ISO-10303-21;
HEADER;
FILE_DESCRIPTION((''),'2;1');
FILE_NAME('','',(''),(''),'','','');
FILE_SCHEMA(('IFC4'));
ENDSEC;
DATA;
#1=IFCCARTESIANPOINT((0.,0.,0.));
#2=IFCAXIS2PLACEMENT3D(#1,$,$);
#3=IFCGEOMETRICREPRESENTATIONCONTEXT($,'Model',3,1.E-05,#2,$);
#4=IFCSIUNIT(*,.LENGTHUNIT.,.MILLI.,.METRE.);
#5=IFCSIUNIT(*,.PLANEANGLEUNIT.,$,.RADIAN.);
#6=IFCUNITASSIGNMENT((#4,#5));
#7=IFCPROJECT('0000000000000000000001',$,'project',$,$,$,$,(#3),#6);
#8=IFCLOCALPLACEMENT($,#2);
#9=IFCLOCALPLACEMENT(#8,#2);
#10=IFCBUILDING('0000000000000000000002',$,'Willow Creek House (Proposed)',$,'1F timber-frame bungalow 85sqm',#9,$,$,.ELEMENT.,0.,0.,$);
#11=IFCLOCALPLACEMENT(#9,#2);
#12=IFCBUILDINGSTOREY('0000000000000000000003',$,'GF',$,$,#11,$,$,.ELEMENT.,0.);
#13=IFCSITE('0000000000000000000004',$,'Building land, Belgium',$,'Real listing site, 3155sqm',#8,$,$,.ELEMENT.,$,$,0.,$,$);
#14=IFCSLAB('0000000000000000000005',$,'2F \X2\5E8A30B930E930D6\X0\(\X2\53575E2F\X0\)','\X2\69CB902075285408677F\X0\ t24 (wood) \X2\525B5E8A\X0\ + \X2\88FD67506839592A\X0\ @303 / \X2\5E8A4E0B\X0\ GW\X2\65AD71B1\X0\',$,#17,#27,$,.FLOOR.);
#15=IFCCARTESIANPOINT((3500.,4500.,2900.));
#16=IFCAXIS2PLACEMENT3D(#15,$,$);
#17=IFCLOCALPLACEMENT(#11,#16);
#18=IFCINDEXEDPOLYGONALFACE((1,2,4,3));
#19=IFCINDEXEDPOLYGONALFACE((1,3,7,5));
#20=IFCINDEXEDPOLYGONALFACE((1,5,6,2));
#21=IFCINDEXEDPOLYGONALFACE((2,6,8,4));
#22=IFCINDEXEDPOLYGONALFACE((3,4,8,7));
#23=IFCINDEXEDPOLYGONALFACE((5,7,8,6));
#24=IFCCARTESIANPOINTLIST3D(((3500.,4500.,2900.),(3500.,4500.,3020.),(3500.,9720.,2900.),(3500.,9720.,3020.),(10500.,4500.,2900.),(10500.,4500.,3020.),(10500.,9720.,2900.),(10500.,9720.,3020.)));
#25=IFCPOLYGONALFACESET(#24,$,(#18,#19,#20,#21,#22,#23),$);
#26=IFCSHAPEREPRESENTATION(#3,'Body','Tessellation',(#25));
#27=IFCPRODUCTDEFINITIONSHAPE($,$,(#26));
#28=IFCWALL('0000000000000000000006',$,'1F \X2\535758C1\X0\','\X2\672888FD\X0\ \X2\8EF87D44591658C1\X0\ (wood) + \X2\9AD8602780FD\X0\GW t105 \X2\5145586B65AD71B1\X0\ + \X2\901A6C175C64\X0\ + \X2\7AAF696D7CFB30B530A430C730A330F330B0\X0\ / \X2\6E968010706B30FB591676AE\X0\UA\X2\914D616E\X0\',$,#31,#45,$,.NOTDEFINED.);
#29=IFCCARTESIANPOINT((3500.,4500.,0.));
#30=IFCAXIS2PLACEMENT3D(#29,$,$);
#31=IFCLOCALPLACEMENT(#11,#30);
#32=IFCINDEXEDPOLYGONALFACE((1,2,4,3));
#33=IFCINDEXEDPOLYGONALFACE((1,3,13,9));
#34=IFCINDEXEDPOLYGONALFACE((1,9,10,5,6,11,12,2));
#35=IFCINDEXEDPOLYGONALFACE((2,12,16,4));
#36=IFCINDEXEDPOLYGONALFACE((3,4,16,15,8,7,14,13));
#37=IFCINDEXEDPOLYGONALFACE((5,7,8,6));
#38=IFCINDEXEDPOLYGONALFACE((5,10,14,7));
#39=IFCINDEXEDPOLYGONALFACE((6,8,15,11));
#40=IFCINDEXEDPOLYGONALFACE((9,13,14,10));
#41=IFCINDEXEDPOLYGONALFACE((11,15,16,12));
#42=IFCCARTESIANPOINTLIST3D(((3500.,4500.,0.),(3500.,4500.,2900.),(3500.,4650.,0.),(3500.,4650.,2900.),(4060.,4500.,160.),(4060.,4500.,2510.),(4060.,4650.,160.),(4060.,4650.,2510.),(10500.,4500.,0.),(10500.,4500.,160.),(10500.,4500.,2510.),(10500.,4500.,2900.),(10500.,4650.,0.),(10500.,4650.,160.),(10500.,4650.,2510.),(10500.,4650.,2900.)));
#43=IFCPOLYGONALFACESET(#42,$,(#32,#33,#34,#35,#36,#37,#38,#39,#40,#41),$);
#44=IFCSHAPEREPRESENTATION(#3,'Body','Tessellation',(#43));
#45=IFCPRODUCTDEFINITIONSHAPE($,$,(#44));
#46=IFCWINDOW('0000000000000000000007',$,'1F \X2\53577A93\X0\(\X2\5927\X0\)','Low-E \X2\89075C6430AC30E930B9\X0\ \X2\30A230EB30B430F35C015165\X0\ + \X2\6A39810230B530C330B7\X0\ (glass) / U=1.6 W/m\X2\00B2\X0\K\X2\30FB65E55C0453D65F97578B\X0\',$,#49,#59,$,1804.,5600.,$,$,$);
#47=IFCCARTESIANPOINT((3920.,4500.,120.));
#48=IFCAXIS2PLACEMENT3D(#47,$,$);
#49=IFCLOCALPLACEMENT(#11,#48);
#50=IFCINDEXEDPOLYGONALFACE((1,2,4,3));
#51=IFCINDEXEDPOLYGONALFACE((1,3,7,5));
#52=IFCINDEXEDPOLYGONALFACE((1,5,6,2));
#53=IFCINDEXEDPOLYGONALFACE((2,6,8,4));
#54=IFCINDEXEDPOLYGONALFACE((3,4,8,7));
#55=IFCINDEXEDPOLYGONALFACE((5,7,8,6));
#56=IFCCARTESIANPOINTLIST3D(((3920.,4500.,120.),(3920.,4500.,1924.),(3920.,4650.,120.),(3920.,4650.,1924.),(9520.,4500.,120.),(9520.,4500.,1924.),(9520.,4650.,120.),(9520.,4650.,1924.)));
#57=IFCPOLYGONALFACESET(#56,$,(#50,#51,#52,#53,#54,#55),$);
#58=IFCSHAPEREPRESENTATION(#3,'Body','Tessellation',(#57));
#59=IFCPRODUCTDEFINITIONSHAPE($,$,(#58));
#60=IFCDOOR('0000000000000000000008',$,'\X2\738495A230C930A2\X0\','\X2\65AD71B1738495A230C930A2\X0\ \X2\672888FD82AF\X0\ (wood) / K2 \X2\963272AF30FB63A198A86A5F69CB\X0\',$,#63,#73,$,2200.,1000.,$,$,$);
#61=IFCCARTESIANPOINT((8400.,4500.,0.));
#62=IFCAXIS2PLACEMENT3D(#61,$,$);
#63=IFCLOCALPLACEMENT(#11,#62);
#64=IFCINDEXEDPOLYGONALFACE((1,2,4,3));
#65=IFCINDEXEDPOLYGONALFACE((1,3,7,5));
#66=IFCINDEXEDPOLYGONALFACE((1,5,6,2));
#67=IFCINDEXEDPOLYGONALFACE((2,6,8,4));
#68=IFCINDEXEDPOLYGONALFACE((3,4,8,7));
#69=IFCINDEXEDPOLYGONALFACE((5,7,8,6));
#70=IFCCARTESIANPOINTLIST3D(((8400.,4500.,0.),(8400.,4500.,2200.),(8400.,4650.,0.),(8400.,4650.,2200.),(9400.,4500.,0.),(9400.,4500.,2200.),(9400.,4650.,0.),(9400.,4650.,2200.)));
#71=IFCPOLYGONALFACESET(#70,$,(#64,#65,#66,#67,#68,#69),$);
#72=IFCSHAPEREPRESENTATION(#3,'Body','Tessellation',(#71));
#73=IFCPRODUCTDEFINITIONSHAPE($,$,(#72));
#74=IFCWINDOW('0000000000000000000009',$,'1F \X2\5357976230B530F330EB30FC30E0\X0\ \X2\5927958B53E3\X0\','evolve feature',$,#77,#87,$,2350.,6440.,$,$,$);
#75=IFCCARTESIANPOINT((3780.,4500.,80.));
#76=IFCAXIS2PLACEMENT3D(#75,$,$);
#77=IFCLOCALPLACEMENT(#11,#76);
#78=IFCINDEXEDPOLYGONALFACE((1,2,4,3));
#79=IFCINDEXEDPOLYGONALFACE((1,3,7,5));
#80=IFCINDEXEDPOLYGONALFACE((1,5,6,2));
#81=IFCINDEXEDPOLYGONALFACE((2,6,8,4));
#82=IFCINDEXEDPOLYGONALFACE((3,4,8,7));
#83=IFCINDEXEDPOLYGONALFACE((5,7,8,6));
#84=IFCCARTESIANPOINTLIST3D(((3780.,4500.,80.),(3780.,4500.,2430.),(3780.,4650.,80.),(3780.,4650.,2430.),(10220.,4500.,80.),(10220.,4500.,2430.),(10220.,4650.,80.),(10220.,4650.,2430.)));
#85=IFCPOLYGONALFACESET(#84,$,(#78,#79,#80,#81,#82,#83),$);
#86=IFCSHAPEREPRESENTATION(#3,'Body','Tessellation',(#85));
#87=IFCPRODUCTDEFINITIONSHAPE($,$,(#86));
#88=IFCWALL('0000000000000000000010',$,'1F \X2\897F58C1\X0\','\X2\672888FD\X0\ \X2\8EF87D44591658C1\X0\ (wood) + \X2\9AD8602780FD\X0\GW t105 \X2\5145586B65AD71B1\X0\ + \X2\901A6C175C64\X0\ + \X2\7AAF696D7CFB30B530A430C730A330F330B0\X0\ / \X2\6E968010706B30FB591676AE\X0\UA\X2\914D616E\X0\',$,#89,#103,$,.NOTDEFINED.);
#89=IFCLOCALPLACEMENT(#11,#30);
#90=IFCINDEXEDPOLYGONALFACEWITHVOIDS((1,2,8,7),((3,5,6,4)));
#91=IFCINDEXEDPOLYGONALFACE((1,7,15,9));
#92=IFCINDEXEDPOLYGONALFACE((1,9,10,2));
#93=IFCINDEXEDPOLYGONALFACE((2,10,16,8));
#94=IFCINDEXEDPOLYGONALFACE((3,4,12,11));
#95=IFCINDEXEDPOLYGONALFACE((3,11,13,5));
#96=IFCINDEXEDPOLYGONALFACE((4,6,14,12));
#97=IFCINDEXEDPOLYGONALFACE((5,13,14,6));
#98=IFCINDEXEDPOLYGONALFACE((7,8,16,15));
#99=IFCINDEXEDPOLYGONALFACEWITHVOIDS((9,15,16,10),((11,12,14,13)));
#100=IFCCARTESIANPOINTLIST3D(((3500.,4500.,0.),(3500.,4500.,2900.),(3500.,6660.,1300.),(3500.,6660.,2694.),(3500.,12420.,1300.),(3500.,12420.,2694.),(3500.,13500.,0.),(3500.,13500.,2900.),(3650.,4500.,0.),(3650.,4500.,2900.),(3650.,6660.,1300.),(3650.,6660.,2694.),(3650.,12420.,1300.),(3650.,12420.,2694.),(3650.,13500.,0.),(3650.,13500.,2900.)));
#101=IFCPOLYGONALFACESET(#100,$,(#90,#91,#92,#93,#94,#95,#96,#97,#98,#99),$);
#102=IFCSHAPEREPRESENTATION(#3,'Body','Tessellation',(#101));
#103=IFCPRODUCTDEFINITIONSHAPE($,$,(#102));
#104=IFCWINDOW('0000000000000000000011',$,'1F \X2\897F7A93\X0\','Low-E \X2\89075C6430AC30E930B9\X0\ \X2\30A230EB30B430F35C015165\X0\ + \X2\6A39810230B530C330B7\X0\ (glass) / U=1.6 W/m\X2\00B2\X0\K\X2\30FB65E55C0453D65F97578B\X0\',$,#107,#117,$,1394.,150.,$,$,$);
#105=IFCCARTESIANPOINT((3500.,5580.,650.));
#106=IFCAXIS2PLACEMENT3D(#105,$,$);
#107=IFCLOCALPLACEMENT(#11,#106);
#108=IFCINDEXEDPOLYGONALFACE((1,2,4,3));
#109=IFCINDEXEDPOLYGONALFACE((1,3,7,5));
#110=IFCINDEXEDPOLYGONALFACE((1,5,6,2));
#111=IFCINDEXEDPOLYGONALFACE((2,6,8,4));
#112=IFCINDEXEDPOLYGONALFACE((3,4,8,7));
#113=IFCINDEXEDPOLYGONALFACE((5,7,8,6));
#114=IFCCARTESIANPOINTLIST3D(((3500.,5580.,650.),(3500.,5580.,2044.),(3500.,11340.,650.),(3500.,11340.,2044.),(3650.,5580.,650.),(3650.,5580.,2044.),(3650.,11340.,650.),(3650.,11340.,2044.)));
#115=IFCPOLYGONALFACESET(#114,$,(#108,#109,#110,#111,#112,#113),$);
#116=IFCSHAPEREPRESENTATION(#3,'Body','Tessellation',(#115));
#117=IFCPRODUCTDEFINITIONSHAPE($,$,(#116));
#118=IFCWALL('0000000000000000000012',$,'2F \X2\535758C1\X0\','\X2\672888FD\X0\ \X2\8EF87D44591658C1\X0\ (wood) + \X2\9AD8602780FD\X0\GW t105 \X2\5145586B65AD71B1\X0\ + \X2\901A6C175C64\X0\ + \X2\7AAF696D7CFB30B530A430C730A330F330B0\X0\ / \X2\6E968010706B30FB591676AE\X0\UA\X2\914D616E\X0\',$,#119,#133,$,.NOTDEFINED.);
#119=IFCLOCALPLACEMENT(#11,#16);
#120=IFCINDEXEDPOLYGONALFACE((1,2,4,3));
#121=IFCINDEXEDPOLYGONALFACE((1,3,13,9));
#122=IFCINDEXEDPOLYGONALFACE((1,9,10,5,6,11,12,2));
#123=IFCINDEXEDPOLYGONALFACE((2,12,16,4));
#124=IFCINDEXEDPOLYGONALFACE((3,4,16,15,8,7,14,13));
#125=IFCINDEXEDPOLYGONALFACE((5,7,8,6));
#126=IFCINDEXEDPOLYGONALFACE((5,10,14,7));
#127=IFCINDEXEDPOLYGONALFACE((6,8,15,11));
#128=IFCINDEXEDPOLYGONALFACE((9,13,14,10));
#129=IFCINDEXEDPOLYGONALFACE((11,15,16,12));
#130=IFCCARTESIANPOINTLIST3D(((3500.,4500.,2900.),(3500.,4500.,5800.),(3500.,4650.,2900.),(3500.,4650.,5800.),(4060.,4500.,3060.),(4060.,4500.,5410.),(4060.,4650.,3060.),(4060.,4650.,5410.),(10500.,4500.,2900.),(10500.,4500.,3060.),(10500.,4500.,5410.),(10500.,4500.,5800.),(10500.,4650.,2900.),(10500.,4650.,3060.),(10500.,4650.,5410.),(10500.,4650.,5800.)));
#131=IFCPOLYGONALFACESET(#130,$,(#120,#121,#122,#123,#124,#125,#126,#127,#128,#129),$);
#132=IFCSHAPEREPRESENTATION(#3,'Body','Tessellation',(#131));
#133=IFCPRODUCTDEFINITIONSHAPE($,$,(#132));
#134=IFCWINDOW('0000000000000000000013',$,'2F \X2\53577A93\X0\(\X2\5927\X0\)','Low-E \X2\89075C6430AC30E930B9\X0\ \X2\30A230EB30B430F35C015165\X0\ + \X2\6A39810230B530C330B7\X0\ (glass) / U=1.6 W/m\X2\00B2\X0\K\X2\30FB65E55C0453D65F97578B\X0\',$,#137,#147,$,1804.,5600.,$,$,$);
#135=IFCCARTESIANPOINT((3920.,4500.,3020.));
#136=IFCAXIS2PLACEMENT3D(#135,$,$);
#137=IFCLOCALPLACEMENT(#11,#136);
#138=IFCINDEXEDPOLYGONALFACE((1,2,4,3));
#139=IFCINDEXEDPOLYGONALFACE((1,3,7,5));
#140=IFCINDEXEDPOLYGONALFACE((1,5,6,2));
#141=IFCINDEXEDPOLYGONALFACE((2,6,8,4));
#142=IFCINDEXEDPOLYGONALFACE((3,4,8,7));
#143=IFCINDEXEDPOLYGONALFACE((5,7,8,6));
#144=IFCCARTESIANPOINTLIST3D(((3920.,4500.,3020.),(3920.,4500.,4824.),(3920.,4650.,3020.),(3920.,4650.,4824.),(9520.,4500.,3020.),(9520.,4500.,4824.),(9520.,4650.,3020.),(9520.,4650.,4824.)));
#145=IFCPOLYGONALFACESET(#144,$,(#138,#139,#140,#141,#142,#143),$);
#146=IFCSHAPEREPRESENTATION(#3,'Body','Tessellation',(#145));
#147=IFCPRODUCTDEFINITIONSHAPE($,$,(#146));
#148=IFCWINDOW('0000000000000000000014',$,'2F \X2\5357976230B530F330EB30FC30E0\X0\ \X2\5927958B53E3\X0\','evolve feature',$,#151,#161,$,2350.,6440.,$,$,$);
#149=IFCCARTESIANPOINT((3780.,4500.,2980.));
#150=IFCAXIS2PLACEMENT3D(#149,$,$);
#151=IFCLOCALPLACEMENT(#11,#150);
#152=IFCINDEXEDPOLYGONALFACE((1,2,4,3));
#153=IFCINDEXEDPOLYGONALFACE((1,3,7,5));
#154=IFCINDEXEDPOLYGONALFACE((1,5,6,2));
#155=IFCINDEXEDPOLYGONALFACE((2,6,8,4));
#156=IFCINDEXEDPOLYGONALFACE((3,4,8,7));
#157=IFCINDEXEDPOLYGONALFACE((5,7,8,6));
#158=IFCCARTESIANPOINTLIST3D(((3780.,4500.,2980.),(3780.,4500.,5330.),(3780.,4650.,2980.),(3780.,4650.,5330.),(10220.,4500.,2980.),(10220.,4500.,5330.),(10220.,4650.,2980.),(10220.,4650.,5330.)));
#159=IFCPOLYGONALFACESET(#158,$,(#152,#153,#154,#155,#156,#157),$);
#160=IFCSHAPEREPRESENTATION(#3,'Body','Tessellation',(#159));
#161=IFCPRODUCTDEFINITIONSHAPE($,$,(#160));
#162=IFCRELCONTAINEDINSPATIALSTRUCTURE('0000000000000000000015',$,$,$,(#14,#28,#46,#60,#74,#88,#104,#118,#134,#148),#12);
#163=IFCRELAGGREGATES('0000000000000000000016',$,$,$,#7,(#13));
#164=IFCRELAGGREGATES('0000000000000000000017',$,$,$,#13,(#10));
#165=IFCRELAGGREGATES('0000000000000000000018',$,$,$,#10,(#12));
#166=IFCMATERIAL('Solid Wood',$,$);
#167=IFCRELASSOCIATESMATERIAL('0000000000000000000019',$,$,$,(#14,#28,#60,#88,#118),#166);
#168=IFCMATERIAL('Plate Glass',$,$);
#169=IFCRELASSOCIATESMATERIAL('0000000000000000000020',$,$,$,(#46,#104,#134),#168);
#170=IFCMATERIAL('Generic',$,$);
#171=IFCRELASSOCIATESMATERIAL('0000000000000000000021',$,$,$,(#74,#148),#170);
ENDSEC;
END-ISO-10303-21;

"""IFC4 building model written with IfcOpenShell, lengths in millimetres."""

from ifc_helpers import new_model, si_unit, frame, frame_2d, origin, place, context, project, spatial, rectangle, extrude, material, element, fill, save


model = new_model("IFC4")

# Units and contexts
model_context = context("Model", 3, precision=1e-05, world=origin())
ifc_project = project(units=[si_unit("LENGTHUNIT", "METRE", prefix="MILLI"), si_unit("PLANEANGLEUNIT", "RADIAN")], contexts=[model_context])

# Site, building, storey
site_placement = place(None, origin())
site = spatial("IfcSite", under=ifc_project, at=site_placement, Name="Building land, Belgium", ObjectType="Real listing site, 3155sqm", CompositionType="ELEMENT", RefElevation=0.0)
building_placement = place(site_placement, origin())
building = spatial("IfcBuilding", under=site, at=building_placement, Name="Willow Creek House (Proposed)", ObjectType="1F timber-frame bungalow 85sqm", CompositionType="ELEMENT", ElevationOfRefHeight=0.0, ElevationOfTerrain=0.0)
storey_placement = place(building_placement, origin())
storey = spatial("IfcBuildingStorey", under=building, at=storey_placement, Name="GF", CompositionType="ELEMENT", Elevation=0.0)

# Slab
ifc_material_1 = material(Name="Solid Wood")
slab_1_placement = place(storey_placement, frame((3500.0, 4500.0, 2900.0)))
element("IfcSlab", 1, at=slab_1_placement, inside=storey, material=ifc_material_1, Name="2F 床スラブ(南帯)", Description="構造用合板 t24 (wood) 剛床 + 製材根太 @303 / 床下 GW断熱", PredefinedType="FLOOR", context=model_context, shape_type="SweptSolid", body=[
    extrude(rectangle(XDim=7000.0, YDim=5220.0, at=frame_2d((3500.0, 2610.0))), frame((3500.0, 4500.0, 2900.0)), (0.0, 0.0, 1.0), 120.0),
])
ifc_material_2 = material(Name="Generic")

# Wall, openings, windows, door
wall_1_placement = place(storey_placement, frame((3500.0, 4500.0, 0.0)))
wall_1 = element("IfcWall", 2, at=wall_1_placement, inside=storey, material=ifc_material_1, Name="1F 南壁", Description="木製 軸組外壁 (wood) + 高性能GW t105 充填断熱 + 通気層 + 窯業系サイディング / 準耐火・外皮UA配慮", PredefinedType="NOTDEFINED", context=model_context, shape_type="SweptSolid", body=[
    extrude(rectangle(XDim=7000.0, YDim=150.0, at=frame_2d((3500.0, 75.0))), frame((3500.0, 4500.0, 0.0)), (0.0, 0.0, 1.0), 2900.0),
])
opening_1_placement = place(storey_placement, frame((3920.0, 4500.0, 120.0)))
opening_1 = element("IfcOpeningElement", 3, at=opening_1_placement, cuts=wall_1, PredefinedType="NOTDEFINED", context=model_context, shape_type="SweptSolid", body=[
    extrude(rectangle(XDim=5600.0, YDim=150.0, at=frame_2d((2800.0, 75.0))), frame((3920.0, 4500.0, 120.0)), (0.0, 0.0, 1.0), 1804.0),
])
opening_2_placement = place(storey_placement, frame((8400.0, 4500.0, 0.0)))
opening_2 = element("IfcOpeningElement", 4, at=opening_2_placement, cuts=wall_1, PredefinedType="NOTDEFINED", context=model_context, shape_type="SweptSolid", body=[
    extrude(rectangle(XDim=1000.0, YDim=150.0, at=frame_2d((500.0, 75.0))), frame((8400.0, 4500.0, 0.0)), (0.0, 0.0, 1.0), 2200.0),
])
opening_3_placement = place(storey_placement, frame((3780.0, 4500.0, 80.0)))
opening_3 = element("IfcOpeningElement", 5, at=opening_3_placement, cuts=wall_1, PredefinedType="NOTDEFINED", context=model_context, shape_type="SweptSolid", body=[
    extrude(rectangle(XDim=6440.0, YDim=150.0, at=frame_2d((3220.0, 75.0))), frame((3780.0, 4500.0, 80.0)), (0.0, 0.0, 1.0), 2350.0),
])
ifc_material_3 = material(Name="Plate Glass")
window_1_placement = place(storey_placement, frame((3920.0, 4500.0, 120.0)))
window_1 = element("IfcWindow", 6, at=window_1_placement, inside=storey, material=ifc_material_3, Name="1F 南窓(大)", Description="Low-E 複層ガラス アルゴン封入 + 樹脂サッシ (glass) / U=1.6 W/m²K・日射取得型", OverallHeight=1804.0, OverallWidth=5600.0, context=model_context, shape_type="SweptSolid", body=[
    extrude(rectangle(XDim=5600.0, YDim=150.0, at=frame_2d((2800.0, 75.0))), frame((3920.0, 4500.0, 120.0)), (0.0, 0.0, 1.0), 1804.0),
])
fill(opening_1, window_1)
door_placement = place(storey_placement, frame((8400.0, 4500.0, 0.0)))
door = element("IfcDoor", 7, at=door_placement, inside=storey, material=ifc_material_1, Name="玄関ドア", Description="断熱玄関ドア 木製芯 (wood) / K2 防犯・採風機構", OverallHeight=2200.0, OverallWidth=1000.0, context=model_context, shape_type="SweptSolid", body=[
    extrude(rectangle(XDim=1000.0, YDim=150.0, at=frame_2d((500.0, 75.0))), frame((8400.0, 4500.0, 0.0)), (0.0, 0.0, 1.0), 2200.0),
])
fill(opening_2, door)
window_2_placement = place(storey_placement, frame((3780.0, 4500.0, 80.0)))
window_2 = element("IfcWindow", 8, at=window_2_placement, inside=storey, material=ifc_material_2, Name="1F 南面サンルーム 大開口", Description="evolve feature", OverallHeight=2350.0, OverallWidth=6440.0, context=model_context, shape_type="SweptSolid", body=[
    extrude(rectangle(XDim=6440.0, YDim=150.0, at=frame_2d((3220.0, 75.0))), frame((3780.0, 4500.0, 80.0)), (0.0, 0.0, 1.0), 2350.0),
])
fill(opening_3, window_2)

# Wall, opening, window
wall_2_placement = place(storey_placement, frame((3500.0, 4500.0, 0.0)))
wall_2 = element("IfcWall", 9, at=wall_2_placement, inside=storey, material=ifc_material_1, Name="1F 西壁", Description="木製 軸組外壁 (wood) + 高性能GW t105 充填断熱 + 通気層 + 窯業系サイディング / 準耐火・外皮UA配慮", PredefinedType="NOTDEFINED", context=model_context, shape_type="SweptSolid", body=[
    extrude(rectangle(XDim=150.0, YDim=9000.0, at=frame_2d((75.0, 4500.0))), frame((3500.0, 4500.0, 0.0)), (0.0, 0.0, 1.0), 2900.0),
])
opening_4_placement = place(storey_placement, frame((3500.0, 5580.0, 650.0)))
opening_4 = element("IfcOpeningElement", 10, at=opening_4_placement, cuts=wall_2, PredefinedType="NOTDEFINED", context=model_context, shape_type="SweptSolid", body=[
    extrude(rectangle(XDim=150.0, YDim=5760.0, at=frame_2d((75.0, 2880.0))), frame((3500.0, 5580.0, 650.0)), (0.0, 0.0, 1.0), 1394.0),
])
window_3_placement = place(storey_placement, frame((3500.0, 5580.0, 650.0)))
window_3 = element("IfcWindow", 11, at=window_3_placement, inside=storey, material=ifc_material_3, Name="1F 西窓", Description="Low-E 複層ガラス アルゴン封入 + 樹脂サッシ (glass) / U=1.6 W/m²K・日射取得型", OverallHeight=1394.0, OverallWidth=150.0, context=model_context, shape_type="SweptSolid", body=[
    extrude(rectangle(XDim=150.0, YDim=5760.0, at=frame_2d((75.0, 2880.0))), frame((3500.0, 5580.0, 650.0)), (0.0, 0.0, 1.0), 1394.0),
])
fill(opening_4, window_3)

# Wall, openings, windows
wall_3_placement = place(storey_placement, frame((3500.0, 4500.0, 2900.0)))
wall_3 = element("IfcWall", 12, at=wall_3_placement, inside=storey, material=ifc_material_1, Name="2F 南壁", Description="木製 軸組外壁 (wood) + 高性能GW t105 充填断熱 + 通気層 + 窯業系サイディング / 準耐火・外皮UA配慮", PredefinedType="NOTDEFINED", context=model_context, shape_type="SweptSolid", body=[
    extrude(rectangle(XDim=7000.0, YDim=150.0, at=frame_2d((3500.0, 75.0))), frame((3500.0, 4500.0, 2900.0)), (0.0, 0.0, 1.0), 2900.0),
])
opening_5_placement = place(storey_placement, frame((3920.0, 4500.0, 3020.0)))
opening_5 = element("IfcOpeningElement", 13, at=opening_5_placement, cuts=wall_3, PredefinedType="NOTDEFINED", context=model_context, shape_type="SweptSolid", body=[
    extrude(rectangle(XDim=5600.0, YDim=150.0, at=frame_2d((2800.0, 75.0))), frame((3920.0, 4500.0, 3020.0)), (0.0, 0.0, 1.0), 1804.0),
])
opening_6_placement = place(storey_placement, frame((3780.0, 4500.0, 2980.0)))
opening_6 = element("IfcOpeningElement", 14, at=opening_6_placement, cuts=wall_3, PredefinedType="NOTDEFINED", context=model_context, shape_type="SweptSolid", body=[
    extrude(rectangle(XDim=6440.0, YDim=150.0, at=frame_2d((3220.0, 75.0))), frame((3780.0, 4500.0, 2980.0)), (0.0, 0.0, 1.0), 2350.0),
])
window_4_placement = place(storey_placement, frame((3920.0, 4500.0, 3020.0)))
window_4 = element("IfcWindow", 15, at=window_4_placement, inside=storey, material=ifc_material_3, Name="2F 南窓(大)", Description="Low-E 複層ガラス アルゴン封入 + 樹脂サッシ (glass) / U=1.6 W/m²K・日射取得型", OverallHeight=1804.0, OverallWidth=5600.0, context=model_context, shape_type="SweptSolid", body=[
    extrude(rectangle(XDim=5600.0, YDim=150.0, at=frame_2d((2800.0, 75.0))), frame((3920.0, 4500.0, 3020.0)), (0.0, 0.0, 1.0), 1804.0),
])
fill(opening_5, window_4)
window_5_placement = place(storey_placement, frame((3780.0, 4500.0, 2980.0)))
window_5 = element("IfcWindow", 16, at=window_5_placement, inside=storey, material=ifc_material_2, Name="2F 南面サンルーム 大開口", Description="evolve feature", OverallHeight=2350.0, OverallWidth=6440.0, context=model_context, shape_type="SweptSolid", body=[
    extrude(rectangle(XDim=6440.0, YDim=150.0, at=frame_2d((3220.0, 75.0))), frame((3780.0, 4500.0, 2980.0)), (0.0, 0.0, 1.0), 2350.0),
])
fill(opening_6, window_5)

save(model, "model.ifc")
